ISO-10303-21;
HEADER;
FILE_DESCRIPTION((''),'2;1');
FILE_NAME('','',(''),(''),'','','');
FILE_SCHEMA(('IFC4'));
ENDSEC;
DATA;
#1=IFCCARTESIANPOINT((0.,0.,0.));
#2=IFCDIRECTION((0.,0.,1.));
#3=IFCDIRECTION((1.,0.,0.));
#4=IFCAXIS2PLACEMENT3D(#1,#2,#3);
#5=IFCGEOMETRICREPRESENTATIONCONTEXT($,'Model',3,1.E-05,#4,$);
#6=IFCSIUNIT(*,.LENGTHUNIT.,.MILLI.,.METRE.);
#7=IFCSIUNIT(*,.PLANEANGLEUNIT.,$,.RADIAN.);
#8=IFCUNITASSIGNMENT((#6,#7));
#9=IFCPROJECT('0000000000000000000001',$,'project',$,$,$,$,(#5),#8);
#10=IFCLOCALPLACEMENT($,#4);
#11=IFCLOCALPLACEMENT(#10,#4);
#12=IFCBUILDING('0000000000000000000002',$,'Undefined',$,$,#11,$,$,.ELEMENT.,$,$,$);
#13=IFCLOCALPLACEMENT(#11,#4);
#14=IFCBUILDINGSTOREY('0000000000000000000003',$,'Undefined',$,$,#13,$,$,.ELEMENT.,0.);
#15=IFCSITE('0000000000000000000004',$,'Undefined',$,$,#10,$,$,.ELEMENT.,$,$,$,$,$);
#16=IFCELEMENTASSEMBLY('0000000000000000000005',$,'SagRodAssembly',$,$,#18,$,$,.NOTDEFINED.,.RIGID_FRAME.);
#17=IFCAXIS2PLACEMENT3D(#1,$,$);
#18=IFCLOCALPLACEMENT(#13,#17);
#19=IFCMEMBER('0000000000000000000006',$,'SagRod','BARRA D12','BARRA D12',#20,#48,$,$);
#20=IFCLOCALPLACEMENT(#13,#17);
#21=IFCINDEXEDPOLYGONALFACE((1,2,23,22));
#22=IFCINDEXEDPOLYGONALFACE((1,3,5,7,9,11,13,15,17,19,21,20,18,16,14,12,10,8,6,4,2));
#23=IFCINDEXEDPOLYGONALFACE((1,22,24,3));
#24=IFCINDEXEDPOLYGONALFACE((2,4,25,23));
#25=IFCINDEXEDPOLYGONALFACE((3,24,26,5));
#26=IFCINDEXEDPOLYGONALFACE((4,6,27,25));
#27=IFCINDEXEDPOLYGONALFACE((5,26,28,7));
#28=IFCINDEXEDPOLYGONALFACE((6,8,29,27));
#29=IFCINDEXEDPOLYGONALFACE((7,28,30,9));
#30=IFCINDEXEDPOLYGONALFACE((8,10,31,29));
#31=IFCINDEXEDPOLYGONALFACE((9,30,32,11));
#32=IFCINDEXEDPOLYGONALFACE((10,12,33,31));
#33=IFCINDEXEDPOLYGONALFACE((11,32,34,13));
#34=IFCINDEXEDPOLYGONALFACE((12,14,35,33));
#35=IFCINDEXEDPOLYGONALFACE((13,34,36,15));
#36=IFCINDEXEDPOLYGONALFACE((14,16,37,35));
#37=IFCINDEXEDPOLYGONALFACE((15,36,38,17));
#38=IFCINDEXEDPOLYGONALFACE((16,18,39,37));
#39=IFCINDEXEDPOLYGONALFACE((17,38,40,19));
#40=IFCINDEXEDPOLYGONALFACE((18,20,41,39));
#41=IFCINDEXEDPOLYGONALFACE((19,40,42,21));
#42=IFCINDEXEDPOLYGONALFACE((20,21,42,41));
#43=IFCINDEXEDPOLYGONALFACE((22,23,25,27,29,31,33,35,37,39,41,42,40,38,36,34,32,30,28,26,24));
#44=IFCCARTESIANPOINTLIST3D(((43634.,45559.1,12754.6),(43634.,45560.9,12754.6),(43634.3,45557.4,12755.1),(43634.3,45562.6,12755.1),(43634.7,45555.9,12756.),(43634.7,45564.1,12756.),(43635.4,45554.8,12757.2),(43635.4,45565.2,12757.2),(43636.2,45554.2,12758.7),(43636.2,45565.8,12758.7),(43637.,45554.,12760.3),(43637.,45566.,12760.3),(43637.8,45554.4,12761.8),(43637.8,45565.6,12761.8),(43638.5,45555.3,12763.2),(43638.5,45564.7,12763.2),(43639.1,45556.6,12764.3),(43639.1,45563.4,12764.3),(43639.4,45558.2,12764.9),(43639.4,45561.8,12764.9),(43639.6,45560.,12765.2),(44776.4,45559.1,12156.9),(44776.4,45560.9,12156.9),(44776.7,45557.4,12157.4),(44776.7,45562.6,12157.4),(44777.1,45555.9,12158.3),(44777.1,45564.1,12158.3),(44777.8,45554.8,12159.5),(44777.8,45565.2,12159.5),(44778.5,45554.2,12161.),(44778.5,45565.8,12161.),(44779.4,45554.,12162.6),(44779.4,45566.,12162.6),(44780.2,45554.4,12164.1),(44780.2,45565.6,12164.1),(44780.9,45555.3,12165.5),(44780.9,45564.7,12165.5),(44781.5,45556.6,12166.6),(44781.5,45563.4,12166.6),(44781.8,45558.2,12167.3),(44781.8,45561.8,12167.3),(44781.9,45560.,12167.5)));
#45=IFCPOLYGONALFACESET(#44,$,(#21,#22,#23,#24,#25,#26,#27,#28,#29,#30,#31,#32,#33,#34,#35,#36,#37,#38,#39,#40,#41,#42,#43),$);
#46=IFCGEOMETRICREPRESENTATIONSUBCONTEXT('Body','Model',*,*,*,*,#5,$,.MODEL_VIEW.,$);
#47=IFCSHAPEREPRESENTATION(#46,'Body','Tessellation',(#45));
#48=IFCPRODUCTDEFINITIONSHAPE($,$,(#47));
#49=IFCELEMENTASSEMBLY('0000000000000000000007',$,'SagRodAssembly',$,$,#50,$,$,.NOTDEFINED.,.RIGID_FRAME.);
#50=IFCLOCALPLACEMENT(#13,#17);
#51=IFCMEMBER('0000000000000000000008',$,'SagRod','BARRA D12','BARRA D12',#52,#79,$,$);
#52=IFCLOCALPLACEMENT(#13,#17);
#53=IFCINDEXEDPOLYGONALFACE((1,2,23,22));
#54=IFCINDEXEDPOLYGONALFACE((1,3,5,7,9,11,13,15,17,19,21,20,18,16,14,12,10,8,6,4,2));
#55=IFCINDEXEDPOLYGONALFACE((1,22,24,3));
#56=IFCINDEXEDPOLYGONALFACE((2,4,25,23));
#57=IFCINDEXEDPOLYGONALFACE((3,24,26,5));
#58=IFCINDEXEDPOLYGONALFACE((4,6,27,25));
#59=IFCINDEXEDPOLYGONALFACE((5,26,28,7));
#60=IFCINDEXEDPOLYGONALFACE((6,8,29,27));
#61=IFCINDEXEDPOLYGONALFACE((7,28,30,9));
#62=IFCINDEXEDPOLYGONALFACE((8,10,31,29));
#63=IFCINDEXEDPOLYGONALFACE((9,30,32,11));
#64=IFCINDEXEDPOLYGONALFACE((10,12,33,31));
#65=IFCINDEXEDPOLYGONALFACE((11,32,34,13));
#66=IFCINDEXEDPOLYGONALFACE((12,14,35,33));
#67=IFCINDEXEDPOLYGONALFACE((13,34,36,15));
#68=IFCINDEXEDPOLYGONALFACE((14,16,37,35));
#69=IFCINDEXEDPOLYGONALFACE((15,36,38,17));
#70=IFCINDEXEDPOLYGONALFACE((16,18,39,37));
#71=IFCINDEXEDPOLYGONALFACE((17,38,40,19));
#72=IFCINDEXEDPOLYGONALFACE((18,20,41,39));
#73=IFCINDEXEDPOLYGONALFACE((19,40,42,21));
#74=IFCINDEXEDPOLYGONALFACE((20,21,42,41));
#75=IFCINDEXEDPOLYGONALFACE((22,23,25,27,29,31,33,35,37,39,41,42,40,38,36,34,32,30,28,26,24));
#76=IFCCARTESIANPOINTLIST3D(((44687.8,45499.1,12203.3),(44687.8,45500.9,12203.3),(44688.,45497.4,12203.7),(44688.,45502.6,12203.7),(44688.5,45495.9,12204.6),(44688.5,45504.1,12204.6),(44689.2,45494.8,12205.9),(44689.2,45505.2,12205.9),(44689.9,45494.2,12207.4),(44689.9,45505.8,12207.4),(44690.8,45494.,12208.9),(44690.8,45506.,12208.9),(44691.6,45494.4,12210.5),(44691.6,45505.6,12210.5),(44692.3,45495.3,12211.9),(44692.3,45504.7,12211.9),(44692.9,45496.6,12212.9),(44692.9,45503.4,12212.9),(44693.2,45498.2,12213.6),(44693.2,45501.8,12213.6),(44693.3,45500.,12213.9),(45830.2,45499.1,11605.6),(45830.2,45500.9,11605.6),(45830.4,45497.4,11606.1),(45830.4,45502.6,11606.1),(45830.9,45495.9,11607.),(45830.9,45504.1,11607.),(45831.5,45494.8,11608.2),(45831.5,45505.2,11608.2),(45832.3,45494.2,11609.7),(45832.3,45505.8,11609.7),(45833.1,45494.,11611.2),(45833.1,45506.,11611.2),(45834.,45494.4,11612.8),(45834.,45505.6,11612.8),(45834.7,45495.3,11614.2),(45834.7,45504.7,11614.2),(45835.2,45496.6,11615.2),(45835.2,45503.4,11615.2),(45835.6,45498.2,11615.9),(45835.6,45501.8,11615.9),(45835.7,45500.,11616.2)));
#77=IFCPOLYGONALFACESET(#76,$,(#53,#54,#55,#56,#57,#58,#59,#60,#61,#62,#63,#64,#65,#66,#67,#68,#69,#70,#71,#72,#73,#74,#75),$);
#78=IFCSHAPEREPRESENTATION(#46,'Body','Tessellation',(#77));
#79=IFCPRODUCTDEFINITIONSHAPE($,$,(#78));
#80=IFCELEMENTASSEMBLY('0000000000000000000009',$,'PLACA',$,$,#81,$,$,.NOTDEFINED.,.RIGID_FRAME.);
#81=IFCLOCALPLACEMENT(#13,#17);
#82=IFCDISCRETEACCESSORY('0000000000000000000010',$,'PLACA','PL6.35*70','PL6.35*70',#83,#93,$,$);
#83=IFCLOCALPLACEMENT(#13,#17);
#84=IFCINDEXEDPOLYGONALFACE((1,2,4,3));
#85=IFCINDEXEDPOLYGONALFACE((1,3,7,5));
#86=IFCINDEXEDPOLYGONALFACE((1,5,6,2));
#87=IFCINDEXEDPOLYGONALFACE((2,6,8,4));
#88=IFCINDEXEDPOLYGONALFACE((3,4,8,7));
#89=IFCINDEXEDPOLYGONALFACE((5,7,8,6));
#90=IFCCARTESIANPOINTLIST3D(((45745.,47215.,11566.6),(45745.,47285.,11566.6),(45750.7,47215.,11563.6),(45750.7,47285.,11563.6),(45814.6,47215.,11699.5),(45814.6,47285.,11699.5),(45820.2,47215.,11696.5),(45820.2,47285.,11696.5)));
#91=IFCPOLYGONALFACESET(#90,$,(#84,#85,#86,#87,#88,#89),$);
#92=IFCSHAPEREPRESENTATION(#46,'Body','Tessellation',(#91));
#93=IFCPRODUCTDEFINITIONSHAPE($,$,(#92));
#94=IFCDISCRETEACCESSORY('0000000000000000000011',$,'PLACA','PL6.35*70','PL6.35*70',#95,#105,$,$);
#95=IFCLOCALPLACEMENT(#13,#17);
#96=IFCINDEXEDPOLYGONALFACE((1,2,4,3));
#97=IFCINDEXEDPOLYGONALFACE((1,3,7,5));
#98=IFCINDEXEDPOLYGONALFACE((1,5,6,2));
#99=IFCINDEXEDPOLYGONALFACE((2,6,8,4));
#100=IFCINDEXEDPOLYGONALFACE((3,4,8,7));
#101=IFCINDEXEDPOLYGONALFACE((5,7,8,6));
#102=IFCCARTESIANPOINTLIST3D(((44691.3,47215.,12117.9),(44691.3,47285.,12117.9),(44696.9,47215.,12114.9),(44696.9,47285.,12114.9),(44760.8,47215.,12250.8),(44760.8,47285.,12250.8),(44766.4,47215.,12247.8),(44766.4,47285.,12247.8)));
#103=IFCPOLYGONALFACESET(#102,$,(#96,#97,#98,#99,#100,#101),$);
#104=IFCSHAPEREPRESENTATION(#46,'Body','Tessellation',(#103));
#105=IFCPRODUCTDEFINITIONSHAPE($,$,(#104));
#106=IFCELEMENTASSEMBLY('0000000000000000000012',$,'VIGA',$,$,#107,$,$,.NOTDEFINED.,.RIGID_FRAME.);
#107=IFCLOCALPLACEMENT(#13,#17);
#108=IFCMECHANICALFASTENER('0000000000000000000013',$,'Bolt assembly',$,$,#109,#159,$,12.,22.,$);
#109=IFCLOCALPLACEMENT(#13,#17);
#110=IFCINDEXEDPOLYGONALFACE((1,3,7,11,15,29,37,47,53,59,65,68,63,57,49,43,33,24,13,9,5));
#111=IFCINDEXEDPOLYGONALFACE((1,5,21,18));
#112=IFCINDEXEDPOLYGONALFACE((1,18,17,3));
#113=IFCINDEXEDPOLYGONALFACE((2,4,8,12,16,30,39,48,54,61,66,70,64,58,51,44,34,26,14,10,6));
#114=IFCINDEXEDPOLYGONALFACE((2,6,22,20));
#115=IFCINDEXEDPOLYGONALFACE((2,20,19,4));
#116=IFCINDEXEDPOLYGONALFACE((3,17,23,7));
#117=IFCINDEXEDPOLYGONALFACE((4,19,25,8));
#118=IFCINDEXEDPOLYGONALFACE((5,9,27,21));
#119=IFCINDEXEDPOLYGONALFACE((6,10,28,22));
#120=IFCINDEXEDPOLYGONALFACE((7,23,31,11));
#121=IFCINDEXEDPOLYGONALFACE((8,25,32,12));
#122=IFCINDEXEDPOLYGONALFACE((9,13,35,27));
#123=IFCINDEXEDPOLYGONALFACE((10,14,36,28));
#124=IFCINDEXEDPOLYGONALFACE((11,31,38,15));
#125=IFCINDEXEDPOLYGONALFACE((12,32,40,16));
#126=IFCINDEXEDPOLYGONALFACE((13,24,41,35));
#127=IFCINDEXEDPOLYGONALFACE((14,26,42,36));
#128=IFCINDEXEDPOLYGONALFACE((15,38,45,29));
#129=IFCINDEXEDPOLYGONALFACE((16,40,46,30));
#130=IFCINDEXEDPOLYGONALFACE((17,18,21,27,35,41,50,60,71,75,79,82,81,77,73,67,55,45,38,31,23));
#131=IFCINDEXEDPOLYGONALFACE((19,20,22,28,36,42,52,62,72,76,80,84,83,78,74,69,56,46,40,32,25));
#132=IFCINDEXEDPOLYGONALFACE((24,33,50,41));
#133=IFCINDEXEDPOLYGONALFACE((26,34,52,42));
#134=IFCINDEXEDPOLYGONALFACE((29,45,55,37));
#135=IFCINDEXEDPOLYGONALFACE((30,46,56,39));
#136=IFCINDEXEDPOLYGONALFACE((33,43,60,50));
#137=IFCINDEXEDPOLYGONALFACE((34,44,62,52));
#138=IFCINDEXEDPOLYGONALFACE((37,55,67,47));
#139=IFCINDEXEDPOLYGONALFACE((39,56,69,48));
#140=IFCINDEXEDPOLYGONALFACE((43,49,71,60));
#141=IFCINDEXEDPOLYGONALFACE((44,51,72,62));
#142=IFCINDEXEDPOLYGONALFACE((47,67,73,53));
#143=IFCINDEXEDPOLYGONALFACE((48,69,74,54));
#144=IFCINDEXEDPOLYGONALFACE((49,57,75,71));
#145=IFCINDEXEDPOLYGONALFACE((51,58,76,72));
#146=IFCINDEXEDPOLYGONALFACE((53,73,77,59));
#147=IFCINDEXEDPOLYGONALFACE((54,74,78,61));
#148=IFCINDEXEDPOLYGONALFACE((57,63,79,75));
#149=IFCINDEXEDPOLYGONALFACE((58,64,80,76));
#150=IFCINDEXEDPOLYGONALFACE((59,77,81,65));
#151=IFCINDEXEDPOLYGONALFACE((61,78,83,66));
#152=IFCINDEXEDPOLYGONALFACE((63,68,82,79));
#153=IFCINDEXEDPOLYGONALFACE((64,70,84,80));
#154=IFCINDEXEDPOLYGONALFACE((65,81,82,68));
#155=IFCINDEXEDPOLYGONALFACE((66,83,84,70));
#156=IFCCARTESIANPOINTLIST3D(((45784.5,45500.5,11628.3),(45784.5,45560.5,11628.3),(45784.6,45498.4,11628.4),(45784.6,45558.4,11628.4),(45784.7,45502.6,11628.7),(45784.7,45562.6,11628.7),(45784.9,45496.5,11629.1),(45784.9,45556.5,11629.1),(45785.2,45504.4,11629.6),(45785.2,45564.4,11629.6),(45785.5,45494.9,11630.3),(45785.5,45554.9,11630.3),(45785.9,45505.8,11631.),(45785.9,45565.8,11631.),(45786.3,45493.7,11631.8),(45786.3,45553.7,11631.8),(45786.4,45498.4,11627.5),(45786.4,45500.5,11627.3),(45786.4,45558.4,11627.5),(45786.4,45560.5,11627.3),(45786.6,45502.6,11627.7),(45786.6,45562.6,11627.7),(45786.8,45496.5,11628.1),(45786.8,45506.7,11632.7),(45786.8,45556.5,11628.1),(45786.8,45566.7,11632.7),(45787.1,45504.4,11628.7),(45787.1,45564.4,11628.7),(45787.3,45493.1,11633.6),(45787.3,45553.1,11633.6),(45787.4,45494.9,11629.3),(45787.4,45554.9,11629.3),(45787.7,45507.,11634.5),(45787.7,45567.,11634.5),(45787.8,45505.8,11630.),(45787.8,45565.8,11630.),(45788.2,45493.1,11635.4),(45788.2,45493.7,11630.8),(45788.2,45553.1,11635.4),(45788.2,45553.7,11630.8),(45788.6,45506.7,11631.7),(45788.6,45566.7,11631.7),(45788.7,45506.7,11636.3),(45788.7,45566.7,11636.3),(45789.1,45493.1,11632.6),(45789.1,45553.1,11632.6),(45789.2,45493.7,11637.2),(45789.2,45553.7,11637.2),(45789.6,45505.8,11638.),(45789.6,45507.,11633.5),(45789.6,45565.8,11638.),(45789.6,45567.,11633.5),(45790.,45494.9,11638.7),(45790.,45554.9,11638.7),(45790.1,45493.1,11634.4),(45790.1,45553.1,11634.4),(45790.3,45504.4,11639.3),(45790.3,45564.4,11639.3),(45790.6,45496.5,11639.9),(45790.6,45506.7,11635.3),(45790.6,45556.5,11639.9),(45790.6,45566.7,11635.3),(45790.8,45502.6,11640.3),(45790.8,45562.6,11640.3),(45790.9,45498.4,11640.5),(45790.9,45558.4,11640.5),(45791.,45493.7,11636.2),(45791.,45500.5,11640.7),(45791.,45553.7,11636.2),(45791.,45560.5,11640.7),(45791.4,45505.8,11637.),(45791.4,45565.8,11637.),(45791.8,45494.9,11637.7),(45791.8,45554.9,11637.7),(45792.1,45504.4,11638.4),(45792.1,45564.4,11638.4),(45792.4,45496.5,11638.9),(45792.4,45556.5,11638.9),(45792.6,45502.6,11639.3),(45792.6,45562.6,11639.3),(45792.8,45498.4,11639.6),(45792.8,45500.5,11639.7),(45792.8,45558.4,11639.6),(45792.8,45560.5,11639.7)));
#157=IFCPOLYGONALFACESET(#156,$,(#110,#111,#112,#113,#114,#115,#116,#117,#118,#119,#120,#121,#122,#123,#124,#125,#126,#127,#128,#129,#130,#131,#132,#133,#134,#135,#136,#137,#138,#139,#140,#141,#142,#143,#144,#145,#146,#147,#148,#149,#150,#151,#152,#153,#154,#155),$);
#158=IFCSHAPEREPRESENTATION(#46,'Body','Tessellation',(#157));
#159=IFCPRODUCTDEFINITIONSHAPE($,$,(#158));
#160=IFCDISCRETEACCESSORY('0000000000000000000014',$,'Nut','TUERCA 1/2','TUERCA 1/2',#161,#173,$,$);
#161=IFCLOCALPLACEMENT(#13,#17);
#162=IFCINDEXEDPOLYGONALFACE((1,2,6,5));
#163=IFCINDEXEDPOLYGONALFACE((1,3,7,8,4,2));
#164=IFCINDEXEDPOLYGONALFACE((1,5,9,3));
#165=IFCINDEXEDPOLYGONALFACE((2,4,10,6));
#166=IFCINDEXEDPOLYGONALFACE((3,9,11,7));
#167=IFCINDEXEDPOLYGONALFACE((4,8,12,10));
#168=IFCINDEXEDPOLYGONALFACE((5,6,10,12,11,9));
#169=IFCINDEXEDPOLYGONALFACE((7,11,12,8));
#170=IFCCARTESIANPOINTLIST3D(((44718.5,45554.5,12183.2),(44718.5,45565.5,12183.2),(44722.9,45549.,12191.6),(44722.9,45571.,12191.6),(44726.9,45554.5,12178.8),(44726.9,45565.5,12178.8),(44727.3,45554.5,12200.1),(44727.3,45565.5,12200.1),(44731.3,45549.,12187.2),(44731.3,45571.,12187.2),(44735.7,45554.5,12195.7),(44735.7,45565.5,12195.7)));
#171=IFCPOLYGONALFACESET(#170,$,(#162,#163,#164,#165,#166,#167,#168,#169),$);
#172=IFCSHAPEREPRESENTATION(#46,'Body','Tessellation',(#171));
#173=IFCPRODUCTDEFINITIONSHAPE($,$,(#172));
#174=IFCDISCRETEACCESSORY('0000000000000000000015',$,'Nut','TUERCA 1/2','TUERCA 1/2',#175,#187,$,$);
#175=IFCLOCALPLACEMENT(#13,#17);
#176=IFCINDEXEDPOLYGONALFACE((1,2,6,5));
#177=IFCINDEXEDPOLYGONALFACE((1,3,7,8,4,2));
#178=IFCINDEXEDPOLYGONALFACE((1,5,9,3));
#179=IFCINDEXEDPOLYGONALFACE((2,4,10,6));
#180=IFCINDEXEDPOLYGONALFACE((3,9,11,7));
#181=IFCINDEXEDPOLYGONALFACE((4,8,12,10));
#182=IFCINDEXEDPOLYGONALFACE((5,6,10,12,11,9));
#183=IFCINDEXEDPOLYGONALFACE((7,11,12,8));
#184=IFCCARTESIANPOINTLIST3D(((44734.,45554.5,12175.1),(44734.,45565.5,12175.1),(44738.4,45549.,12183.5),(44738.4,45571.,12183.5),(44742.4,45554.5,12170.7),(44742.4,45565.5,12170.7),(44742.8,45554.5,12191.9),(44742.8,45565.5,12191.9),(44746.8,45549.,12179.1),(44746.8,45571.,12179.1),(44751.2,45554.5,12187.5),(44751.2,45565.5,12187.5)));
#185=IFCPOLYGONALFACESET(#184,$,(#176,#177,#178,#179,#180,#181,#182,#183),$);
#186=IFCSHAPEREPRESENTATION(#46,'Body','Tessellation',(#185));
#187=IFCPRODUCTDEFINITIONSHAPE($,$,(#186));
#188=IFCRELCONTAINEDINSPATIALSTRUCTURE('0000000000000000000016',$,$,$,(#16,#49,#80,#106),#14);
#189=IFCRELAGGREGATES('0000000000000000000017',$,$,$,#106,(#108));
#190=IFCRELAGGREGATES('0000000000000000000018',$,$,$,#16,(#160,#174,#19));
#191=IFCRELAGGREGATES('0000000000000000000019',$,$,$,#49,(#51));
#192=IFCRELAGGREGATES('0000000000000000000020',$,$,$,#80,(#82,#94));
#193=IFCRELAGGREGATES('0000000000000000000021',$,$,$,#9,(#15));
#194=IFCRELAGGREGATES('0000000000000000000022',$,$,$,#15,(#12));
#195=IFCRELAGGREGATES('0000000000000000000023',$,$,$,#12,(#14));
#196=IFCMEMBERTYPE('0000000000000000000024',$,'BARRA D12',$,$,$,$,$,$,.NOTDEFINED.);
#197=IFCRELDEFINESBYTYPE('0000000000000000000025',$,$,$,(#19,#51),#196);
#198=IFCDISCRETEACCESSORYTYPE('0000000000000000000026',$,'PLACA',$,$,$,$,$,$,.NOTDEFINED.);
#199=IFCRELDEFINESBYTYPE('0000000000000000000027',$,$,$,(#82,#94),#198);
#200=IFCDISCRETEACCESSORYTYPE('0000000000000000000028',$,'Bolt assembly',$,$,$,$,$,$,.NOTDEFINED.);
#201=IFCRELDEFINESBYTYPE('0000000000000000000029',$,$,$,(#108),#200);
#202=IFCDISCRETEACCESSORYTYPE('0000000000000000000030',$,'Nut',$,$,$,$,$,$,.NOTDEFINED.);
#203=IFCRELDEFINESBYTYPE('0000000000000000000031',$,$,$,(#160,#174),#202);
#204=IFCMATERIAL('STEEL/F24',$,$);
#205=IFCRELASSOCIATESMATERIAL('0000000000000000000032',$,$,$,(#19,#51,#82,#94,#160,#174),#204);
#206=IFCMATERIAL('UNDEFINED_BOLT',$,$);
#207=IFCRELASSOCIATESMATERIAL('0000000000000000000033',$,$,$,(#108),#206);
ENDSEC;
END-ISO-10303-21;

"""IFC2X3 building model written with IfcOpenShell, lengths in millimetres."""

from ifc_helpers import new_model, si_unit, frame, origin_with_axes, origin_2d_with_axis, place, context, subcontext, project, spatial, polyline, rectangle, circle, outline, extrude, source, transform, mapped, material, type_object, element, aggregate, save


model = new_model("IFC2X3")

# Units and contexts
model_context = context("Model", 3, precision=1e-05, world=origin_with_axes())
body_context = subcontext(model_context, "Body", "Model", "MODEL_VIEW")
ifc_project = project(units=[si_unit("LENGTHUNIT", "METRE", prefix="MILLI"), si_unit("PLANEANGLEUNIT", "RADIAN")], contexts=[model_context])

# Site, building, storey
site_placement = place(None, origin_with_axes())
site = spatial("IfcSite", under=ifc_project, at=site_placement, Name="Undefined", CompositionType="ELEMENT")
building_placement = place(site_placement, origin_with_axes())
building = spatial("IfcBuilding", under=site, at=building_placement, Name="Undefined", CompositionType="ELEMENT")
storey_placement = place(building_placement, origin_with_axes())
storey = spatial("IfcBuildingStorey", under=building, at=storey_placement, Name="Undefined", CompositionType="ELEMENT", Elevation=0.0)

# Element assemblies, members
assembly_1_placement = place(storey_placement, origin_with_axes())
assembly_1 = element("IfcElementAssembly", 1, at=assembly_1_placement, inside=storey, Name="SagRodAssembly", AssemblyPlace="NOTDEFINED", PredefinedType="RIGID_FRAME")
ifc_material_1 = material(Name="STEEL/F24")
member_type = type_object("IfcMemberType", Name="BARRA D12", PredefinedType="NOTDEFINED")
member_1_placement = place(assembly_1_placement, frame((44779.2, 45560.0, 12162.2), z_axis=(0.0, -1.0, 0.0), x_axis=(-0.886056, 0.0, 0.463578)))
member_1 = element("IfcMember", 2, at=member_1_placement, type_object=member_type, material=ifc_material_1, Name="SagRod", Description="BARRA D12", ObjectType="BARRA D12", context=body_context, shape_type="SweptSolid", body=[
    extrude(circle(Radius=6.0, at=origin_2d_with_axis()), frame((1289.3, 0.0, 0.0), z_axis=(-1.0, 0.0, 0.0), x_axis=(0.0, -1.0, 0.0)), (0.0, 0.0, 1.0), 1289.3),
])
assembly_2_placement = place(storey_placement, origin_with_axes())
assembly_2 = element("IfcElementAssembly", 3, at=assembly_2_placement, inside=storey, Name="SagRodAssembly", AssemblyPlace="NOTDEFINED", PredefinedType="RIGID_FRAME")
member_2_placement = place(assembly_2_placement, frame((45832.9, 45500.0, 11610.9), z_axis=(0.0, -1.0, 0.0), x_axis=(-0.886056, 0.0, 0.463578)))
member_2 = element("IfcMember", 4, at=member_2_placement, type_object=member_type, material=ifc_material_1, Name="SagRod", Description="BARRA D12", ObjectType="BARRA D12", context=body_context, shape_type="SweptSolid", body=[
    extrude(circle(Radius=6.0, at=origin_2d_with_axis()), frame((1289.3, 0.0, 0.0), z_axis=(-1.0, 0.0, 0.0), x_axis=(0.0, -1.0, 0.0)), (0.0, 0.0, 1.0), 1289.3),
])

# Element assembly, discrete accessories
assembly_3_placement = place(storey_placement, origin_with_axes())
assembly_3 = element("IfcElementAssembly", 5, at=assembly_3_placement, inside=storey, Name="PLACA", AssemblyPlace="NOTDEFINED", PredefinedType="RIGID_FRAME")
discrete_accessory_type_1 = type_object("IfcDiscreteAccessoryType", Name="PLACA")
discrete_accessory_1_placement = place(assembly_3_placement, frame((45817.4, 47250.0, 11698.0), z_axis=(0.0, 1.0, 0.0), x_axis=(-0.463605, 0.0, -0.886042)))
discrete_accessory_1 = element("IfcDiscreteAccessory", 6, at=discrete_accessory_1_placement, type_object=discrete_accessory_type_1, material=ifc_material_1, Name="PLACA", Description="PL6.35*70", ObjectType="PL6.35*70", context=body_context, shape_type="SweptSolid", body=[
    extrude(rectangle(XDim=6.3, YDim=70.0, at=origin_2d_with_axis()), frame((150.0, 0.0, 0.0), z_axis=(-1.0, 0.0, 0.0), x_axis=(0.0, -1.0, 0.0)), (0.0, 0.0, 1.0), 150.0),
])
discrete_accessory_2_placement = place(assembly_3_placement, frame((44763.6, 47250.0, 12249.3), z_axis=(0.0, 1.0, 0.0), x_axis=(-0.463605, 0.0, -0.886042)))
discrete_accessory_2 = element("IfcDiscreteAccessory", 7, at=discrete_accessory_2_placement, type_object=discrete_accessory_type_1, material=ifc_material_1, Name="PLACA", Description="PL6.35*70", ObjectType="PL6.35*70", context=body_context, shape_type="SweptSolid", body=[
    extrude(rectangle(XDim=6.3, YDim=70.0, at=origin_2d_with_axis()), frame((150.0, 0.0, 0.0), z_axis=(-1.0, 0.0, 0.0), x_axis=(0.0, -1.0, 0.0)), (0.0, 0.0, 1.0), 150.0),
])

# Element assembly, mechanical fastener
assembly_4_placement = place(storey_placement, origin_with_axes())
assembly_4 = element("IfcElementAssembly", 8, at=assembly_4_placement, inside=storey, Name="VIGA", AssemblyPlace="NOTDEFINED", PredefinedType="RIGID_FRAME")
ifc_material_2 = material(Name="UNDEFINED_BOLT")
discrete_accessory_type_2 = type_object("IfcDiscreteAccessoryType", Name="Bolt assembly")
shared_shape_1 = source(origin_with_axes(), body_context, "Body", "SweptSolid", [
    extrude(circle(Radius=7.0, at=origin_2d_with_axis()), frame((0.0, -1.0, 0.0), z_axis=(0.0, 1.0, 0.0), x_axis=(1.0, 0.0, 0.0)), (0.0, 0.0, 1.0), 2.1),
])
mechanical_fastener_1_placement = place(assembly_4_placement, frame((45788.6, 45500.0, 11634.0), z_axis=(-0.463605, 0.0, -0.886042), x_axis=(0.0, 1.0, 0.0)))
mechanical_fastener_1 = element("IfcMechanicalFastener", 9, at=mechanical_fastener_1_placement, type_object=discrete_accessory_type_2, material=ifc_material_2, Name="Bolt assembly", NominalDiameter=12.0, NominalLength=22.0, context=body_context, shape_type="MappedRepresentation", body=[
    mapped(shared_shape_1, transform((0.0, 0.0, 0.0))),
    mapped(shared_shape_1, transform((60.0, 0.0, 0.0))),
])
aggregate(assembly_4, [mechanical_fastener_1])

# Discrete accessories
discrete_accessory_type_3 = type_object("IfcDiscreteAccessoryType", Name="Nut")
discrete_accessory_3_placement = place(assembly_1_placement, frame((44731.3, 45560.0, 12187.2), z_axis=(-0.463578, 0.0, -0.886056), x_axis=(-0.886056, 0.0, 0.463578)))
discrete_accessory_3 = element("IfcDiscreteAccessory", 10, at=discrete_accessory_3_placement, type_object=discrete_accessory_type_3, material=ifc_material_1, Name="Nut", Description="TUERCA 1/2", ObjectType="TUERCA 1/2", context=body_context, shape_type="SweptSolid", body=[
    extrude(outline(polyline([(-5.5, 9.5), (5.5, 9.5), (11.0, 0.0), (5.5, -9.5), (-5.5, -9.5), (-11.0, 0.0), (-5.5, 9.5)])), frame((9.5, 0.0, 0.0), z_axis=(-1.0, 0.0, 0.0), x_axis=(0.0, -1.0, 0.0)), (0.0, 0.0, 1.0), 9.5),
])
discrete_accessory_4_placement = place(assembly_1_placement, frame((44746.8, 45560.0, 12179.1), z_axis=(-0.463578, 0.0, -0.886056), x_axis=(-0.886056, 0.0, 0.463578)))
discrete_accessory_4 = element("IfcDiscreteAccessory", 11, at=discrete_accessory_4_placement, type_object=discrete_accessory_type_3, material=ifc_material_1, Name="Nut", Description="TUERCA 1/2", ObjectType="TUERCA 1/2", context=body_context, shape_type="SweptSolid", body=[
    extrude(outline(polyline([(-5.5, 9.5), (5.5, 9.5), (11.0, 0.0), (5.5, -9.5), (-5.5, -9.5), (-11.0, 0.0), (-5.5, 9.5)])), frame((9.5, 0.0, 0.0), z_axis=(-1.0, 0.0, 0.0), x_axis=(0.0, -1.0, 0.0)), (0.0, 0.0, 1.0), 9.5),
])

aggregate(assembly_1, [discrete_accessory_3, discrete_accessory_4, member_1])
aggregate(assembly_2, [member_2])

aggregate(assembly_3, [discrete_accessory_1, discrete_accessory_2])

save(model, "model.ifc")
